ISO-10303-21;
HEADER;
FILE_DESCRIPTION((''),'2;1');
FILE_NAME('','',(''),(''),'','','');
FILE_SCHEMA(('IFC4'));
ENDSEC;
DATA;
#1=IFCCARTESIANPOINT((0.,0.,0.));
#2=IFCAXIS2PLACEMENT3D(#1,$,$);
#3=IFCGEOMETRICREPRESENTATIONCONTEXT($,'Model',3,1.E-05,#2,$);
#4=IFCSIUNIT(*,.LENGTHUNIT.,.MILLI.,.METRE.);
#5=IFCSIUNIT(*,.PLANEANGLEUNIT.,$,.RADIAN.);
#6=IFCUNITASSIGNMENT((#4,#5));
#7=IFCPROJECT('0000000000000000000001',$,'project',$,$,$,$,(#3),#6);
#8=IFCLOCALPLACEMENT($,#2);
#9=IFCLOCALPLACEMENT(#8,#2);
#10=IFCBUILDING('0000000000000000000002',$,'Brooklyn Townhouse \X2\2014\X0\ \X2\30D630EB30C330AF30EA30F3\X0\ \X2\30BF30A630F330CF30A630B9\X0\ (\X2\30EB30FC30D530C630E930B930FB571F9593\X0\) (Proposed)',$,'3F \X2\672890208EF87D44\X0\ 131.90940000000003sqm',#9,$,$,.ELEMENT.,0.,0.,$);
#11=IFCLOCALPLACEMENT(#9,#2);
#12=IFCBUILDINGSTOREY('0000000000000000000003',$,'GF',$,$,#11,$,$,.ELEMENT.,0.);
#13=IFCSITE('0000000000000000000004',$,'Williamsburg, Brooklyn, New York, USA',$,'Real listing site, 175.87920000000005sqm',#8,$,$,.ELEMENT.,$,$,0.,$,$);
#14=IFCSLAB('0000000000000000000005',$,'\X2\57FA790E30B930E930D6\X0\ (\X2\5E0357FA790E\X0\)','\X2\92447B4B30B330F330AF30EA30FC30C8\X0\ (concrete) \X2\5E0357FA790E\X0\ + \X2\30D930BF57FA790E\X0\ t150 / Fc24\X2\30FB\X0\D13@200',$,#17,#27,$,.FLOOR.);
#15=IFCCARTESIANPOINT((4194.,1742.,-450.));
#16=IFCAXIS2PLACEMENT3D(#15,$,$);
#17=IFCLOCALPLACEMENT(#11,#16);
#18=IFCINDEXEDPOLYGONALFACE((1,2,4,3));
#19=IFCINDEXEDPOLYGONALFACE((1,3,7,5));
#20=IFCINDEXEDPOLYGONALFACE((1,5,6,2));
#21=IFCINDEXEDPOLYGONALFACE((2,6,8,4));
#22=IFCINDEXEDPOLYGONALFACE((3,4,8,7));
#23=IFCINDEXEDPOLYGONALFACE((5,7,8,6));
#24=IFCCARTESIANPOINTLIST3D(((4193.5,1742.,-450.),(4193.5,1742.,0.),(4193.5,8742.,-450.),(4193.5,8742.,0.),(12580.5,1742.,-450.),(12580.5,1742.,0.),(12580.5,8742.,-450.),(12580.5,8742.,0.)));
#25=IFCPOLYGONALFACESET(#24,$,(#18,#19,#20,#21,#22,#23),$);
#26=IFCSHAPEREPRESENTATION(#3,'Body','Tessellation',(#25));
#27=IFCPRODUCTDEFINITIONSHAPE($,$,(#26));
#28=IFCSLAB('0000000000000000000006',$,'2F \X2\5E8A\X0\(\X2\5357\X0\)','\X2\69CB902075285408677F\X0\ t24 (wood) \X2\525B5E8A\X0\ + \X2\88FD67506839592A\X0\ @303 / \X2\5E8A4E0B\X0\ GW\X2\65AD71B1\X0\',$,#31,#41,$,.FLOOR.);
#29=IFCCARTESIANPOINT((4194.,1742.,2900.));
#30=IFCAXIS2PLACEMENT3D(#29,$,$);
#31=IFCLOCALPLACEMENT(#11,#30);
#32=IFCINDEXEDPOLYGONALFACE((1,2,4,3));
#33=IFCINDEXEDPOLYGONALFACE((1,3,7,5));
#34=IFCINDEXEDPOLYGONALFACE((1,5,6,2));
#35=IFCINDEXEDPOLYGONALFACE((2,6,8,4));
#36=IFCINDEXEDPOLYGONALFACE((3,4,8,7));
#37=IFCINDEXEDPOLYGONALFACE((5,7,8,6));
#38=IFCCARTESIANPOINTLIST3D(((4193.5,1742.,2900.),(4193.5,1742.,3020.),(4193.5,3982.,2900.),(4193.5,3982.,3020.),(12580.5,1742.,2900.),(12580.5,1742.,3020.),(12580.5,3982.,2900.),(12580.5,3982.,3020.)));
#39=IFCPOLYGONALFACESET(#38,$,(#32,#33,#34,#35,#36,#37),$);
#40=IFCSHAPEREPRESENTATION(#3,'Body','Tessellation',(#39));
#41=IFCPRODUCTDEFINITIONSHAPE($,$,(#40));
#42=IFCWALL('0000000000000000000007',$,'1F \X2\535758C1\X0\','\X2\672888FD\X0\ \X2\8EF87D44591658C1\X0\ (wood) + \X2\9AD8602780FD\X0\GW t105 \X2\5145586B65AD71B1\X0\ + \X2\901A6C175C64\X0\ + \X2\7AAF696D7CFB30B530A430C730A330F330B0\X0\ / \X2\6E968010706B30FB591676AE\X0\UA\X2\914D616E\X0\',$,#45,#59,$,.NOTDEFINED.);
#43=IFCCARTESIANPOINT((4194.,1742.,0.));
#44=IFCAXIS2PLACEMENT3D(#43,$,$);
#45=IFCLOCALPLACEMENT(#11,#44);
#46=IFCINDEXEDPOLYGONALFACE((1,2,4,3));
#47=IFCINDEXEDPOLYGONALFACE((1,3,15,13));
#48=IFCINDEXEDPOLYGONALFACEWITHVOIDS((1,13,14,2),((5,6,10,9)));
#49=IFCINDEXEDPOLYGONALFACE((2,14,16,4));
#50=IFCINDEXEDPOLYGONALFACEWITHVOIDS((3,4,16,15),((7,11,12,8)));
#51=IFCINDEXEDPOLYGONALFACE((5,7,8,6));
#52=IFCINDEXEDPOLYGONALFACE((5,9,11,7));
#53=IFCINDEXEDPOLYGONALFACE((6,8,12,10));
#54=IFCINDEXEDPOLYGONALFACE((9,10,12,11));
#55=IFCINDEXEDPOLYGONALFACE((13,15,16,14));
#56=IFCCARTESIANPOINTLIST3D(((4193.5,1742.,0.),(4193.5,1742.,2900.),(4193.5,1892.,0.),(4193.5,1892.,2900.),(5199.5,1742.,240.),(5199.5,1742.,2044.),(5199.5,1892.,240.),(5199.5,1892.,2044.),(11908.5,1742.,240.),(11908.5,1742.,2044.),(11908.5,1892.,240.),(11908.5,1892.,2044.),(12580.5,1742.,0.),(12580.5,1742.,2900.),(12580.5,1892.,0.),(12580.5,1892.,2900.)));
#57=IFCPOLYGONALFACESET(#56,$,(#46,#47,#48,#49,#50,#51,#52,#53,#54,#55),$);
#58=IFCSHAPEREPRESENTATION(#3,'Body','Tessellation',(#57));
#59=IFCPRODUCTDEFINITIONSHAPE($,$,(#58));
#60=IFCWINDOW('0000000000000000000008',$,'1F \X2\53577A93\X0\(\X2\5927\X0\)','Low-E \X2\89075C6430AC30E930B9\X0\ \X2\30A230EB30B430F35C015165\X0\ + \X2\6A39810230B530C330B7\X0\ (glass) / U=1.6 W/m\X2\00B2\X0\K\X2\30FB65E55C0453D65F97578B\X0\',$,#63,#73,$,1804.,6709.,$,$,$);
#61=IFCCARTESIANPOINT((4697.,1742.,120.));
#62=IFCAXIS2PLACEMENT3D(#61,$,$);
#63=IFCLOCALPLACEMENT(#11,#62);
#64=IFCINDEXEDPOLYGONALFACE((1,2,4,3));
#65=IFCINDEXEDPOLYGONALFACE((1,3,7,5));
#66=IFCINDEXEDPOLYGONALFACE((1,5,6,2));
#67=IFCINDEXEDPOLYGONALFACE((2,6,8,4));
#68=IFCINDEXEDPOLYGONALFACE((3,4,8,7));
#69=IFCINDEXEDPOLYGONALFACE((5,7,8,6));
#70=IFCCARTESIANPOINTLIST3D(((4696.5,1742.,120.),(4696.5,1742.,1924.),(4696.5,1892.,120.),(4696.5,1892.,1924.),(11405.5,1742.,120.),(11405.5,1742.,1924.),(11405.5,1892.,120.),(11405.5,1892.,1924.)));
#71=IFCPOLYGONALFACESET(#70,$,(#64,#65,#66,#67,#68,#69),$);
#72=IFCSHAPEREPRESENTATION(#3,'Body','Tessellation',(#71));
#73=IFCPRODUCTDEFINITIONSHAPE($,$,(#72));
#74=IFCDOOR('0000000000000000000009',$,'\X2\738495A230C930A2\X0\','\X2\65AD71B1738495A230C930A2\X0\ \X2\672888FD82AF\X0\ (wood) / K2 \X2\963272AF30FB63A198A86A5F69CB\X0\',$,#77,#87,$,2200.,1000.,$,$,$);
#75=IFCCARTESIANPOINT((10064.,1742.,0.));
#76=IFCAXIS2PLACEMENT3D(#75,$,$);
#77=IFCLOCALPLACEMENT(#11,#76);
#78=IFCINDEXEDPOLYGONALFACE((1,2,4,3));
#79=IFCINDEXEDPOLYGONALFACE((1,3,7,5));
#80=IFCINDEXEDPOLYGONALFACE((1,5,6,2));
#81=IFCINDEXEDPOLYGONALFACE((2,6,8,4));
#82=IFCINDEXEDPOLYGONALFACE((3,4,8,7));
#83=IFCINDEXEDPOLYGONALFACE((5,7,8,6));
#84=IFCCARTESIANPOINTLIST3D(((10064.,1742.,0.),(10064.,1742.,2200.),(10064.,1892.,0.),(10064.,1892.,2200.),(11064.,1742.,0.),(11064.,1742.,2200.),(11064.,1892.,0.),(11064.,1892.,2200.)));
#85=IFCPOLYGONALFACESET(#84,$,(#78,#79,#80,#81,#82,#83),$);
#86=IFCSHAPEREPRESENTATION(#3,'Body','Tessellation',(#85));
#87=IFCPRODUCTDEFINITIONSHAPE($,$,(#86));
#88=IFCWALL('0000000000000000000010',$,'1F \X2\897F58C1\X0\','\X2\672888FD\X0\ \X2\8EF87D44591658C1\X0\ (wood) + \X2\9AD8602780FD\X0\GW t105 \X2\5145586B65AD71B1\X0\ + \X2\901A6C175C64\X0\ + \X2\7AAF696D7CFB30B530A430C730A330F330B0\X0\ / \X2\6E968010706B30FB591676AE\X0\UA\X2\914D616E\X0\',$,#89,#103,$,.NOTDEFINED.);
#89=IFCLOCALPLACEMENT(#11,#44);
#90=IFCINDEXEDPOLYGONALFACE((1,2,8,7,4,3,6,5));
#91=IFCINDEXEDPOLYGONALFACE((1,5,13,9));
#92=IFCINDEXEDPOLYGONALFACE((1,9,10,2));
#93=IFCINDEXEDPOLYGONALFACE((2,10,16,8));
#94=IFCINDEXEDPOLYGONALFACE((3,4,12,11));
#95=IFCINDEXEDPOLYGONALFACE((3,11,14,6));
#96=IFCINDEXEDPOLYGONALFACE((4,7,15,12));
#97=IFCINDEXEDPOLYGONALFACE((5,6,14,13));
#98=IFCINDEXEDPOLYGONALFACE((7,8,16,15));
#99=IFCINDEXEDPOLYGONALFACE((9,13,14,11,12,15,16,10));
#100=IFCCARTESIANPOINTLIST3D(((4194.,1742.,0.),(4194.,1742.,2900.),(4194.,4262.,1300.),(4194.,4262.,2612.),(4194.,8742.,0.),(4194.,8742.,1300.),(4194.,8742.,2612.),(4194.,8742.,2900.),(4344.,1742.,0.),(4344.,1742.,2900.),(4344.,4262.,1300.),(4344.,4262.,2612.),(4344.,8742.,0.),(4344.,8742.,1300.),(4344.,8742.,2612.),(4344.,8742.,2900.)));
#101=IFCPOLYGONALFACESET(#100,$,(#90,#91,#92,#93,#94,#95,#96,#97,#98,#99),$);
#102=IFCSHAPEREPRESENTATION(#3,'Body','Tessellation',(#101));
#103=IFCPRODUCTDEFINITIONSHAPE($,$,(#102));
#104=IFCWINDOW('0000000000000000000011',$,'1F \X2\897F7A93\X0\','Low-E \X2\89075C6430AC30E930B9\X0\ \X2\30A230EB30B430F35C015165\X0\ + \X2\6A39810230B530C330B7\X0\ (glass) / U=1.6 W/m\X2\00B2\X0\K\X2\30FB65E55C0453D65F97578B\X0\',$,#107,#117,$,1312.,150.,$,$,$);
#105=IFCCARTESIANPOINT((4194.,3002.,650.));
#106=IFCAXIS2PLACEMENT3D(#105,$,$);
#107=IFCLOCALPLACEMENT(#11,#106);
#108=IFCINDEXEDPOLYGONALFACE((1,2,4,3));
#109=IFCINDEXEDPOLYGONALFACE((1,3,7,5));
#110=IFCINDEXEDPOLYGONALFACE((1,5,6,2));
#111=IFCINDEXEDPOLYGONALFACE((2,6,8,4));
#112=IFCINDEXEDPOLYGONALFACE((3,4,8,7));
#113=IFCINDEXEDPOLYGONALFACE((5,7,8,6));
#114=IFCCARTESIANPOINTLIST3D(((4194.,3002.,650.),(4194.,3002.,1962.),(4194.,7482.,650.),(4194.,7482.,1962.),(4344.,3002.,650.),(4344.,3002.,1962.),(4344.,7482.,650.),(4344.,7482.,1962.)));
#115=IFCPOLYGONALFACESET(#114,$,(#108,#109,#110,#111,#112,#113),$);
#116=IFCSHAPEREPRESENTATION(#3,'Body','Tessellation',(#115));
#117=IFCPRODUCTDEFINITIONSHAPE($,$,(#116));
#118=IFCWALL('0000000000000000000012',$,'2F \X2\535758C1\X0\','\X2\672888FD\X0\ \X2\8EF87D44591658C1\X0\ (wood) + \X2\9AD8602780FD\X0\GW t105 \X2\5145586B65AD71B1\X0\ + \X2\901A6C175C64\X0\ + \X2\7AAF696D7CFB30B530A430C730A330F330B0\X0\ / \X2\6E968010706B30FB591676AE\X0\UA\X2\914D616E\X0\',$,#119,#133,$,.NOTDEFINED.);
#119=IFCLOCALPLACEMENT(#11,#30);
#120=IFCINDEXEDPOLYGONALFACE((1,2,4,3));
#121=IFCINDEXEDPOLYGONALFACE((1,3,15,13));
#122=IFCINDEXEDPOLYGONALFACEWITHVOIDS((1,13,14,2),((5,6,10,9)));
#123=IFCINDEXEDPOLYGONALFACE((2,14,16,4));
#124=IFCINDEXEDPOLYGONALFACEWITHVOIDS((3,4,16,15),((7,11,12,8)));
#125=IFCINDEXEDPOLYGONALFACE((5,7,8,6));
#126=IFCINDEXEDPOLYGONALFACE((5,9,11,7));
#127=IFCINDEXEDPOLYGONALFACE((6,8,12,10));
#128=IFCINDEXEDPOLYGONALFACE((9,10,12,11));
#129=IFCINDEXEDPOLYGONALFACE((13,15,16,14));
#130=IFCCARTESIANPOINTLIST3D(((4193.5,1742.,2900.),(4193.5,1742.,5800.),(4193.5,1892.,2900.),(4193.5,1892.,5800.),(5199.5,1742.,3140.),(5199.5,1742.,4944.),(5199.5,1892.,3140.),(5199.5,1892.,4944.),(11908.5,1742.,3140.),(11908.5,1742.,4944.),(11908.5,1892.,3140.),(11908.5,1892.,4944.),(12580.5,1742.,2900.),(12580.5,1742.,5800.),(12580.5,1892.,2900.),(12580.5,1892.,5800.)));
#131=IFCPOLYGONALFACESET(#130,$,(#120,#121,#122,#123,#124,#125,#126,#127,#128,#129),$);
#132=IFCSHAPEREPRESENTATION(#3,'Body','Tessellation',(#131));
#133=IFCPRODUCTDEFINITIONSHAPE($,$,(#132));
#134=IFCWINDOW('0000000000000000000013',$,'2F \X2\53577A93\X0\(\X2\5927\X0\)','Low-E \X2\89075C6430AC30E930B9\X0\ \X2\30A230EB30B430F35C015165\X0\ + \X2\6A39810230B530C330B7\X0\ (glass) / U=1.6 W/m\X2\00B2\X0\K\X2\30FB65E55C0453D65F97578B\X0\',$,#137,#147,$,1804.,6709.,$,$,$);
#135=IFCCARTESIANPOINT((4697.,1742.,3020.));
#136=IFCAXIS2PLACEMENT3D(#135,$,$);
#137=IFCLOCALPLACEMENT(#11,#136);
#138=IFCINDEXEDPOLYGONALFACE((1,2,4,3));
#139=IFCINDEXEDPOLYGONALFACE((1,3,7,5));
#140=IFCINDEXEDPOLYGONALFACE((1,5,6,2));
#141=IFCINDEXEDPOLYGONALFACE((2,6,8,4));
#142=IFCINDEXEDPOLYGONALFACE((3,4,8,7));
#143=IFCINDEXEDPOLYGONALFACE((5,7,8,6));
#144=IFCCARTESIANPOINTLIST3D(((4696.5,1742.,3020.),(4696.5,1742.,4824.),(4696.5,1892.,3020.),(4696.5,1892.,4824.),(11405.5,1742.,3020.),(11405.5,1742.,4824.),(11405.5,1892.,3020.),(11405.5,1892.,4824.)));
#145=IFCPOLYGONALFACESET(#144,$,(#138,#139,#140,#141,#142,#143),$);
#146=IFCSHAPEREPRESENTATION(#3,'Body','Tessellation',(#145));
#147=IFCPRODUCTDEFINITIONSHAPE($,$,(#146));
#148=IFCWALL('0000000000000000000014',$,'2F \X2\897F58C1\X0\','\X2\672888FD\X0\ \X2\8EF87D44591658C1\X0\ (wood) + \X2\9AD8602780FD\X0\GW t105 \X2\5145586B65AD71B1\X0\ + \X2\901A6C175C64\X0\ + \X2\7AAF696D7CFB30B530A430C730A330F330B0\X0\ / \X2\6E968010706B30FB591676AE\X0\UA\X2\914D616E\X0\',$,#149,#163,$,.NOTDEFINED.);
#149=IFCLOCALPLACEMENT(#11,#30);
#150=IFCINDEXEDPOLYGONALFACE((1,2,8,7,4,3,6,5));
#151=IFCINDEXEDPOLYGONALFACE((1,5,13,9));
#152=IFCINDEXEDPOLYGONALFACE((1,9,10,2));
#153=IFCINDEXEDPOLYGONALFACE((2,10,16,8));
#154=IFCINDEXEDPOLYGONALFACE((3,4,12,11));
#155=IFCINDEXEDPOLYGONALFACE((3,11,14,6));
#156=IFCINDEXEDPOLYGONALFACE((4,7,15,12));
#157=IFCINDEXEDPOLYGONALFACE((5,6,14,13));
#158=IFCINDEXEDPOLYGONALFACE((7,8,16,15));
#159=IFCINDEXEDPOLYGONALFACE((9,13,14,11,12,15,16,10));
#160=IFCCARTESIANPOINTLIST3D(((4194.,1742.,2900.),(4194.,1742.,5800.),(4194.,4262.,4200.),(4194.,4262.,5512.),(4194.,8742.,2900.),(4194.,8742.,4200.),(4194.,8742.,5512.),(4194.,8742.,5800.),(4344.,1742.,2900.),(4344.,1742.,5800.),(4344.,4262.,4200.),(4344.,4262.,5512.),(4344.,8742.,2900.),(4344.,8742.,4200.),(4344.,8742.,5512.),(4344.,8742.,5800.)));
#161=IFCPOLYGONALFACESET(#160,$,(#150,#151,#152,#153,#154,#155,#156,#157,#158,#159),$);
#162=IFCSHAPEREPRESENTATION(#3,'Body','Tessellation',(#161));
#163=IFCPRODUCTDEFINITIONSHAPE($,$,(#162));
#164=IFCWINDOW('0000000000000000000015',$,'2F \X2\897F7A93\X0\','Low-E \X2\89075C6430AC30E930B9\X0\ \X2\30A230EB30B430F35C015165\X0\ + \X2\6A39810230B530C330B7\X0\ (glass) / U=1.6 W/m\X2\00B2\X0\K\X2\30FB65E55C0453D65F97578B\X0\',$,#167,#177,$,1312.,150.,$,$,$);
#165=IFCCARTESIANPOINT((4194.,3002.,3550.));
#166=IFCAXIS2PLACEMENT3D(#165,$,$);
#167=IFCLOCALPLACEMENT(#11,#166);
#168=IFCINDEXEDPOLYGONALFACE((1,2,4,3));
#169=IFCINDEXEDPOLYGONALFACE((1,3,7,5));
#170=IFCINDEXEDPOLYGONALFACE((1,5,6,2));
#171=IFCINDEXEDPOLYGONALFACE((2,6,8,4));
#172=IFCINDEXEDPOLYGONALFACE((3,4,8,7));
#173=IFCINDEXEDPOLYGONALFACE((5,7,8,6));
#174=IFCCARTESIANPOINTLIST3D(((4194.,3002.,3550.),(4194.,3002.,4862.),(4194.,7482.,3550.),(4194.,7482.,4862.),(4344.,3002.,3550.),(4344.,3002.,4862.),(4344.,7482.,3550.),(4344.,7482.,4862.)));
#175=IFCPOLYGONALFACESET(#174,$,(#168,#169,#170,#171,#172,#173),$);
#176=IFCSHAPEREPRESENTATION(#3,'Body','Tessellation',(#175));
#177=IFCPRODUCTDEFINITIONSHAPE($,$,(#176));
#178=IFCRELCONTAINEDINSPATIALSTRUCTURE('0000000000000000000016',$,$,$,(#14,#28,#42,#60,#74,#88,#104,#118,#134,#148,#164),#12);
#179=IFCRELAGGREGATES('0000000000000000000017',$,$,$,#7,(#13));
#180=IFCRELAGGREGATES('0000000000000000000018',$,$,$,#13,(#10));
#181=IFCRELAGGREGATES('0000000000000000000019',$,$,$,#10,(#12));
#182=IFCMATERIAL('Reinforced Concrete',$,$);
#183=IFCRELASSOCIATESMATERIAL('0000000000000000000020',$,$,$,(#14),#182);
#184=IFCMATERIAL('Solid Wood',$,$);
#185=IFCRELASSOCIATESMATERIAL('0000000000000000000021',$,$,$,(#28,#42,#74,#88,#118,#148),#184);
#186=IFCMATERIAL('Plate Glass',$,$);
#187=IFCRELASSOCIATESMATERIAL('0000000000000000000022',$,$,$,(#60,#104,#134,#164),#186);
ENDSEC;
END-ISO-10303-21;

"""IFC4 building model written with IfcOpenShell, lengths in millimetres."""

from ifc_helpers import new_model, si_unit, frame, frame_2d, origin, place, context, project, spatial, rectangle, extrude, material, element, fill, save


model = new_model("IFC4")

# Units and contexts
model_context = context("Model", 3, precision=1e-05, world=origin())
ifc_project = project(units=[si_unit("LENGTHUNIT", "METRE", prefix="MILLI"), si_unit("PLANEANGLEUNIT", "RADIAN")], contexts=[model_context])

# Site, building, storey
site_placement = place(None, origin())
site = spatial("IfcSite", under=ifc_project, at=site_placement, Name="Williamsburg, Brooklyn, New York, USA", ObjectType="Real listing site, 175.87920000000005sqm", CompositionType="ELEMENT", RefElevation=0.0)
building_placement = place(site_placement, origin())
building = spatial("IfcBuilding", under=site, at=building_placement, Name="Brooklyn Townhouse — ブルックリン タウンハウス (ルーフテラス・土間) (Proposed)", ObjectType="3F 木造軸組 131.90940000000003sqm", CompositionType="ELEMENT", ElevationOfRefHeight=0.0, ElevationOfTerrain=0.0)
storey_placement = place(building_placement, origin())
storey = spatial("IfcBuildingStorey", under=building, at=storey_placement, Name="GF", CompositionType="ELEMENT", Elevation=0.0)

# Slabs
ifc_material_1 = material(Name="Reinforced Concrete")
slab_1_placement = place(storey_placement, frame((4194.0, 1742.0, -450.0)))
element("IfcSlab", 1, at=slab_1_placement, inside=storey, material=ifc_material_1, Name="基礎スラブ (布基礎)", Description="鉄筋コンクリート (concrete) 布基礎 + ベタ基礎 t150 / Fc24・D13@200", PredefinedType="FLOOR", context=model_context, shape_type="SweptSolid", body=[
    extrude(rectangle(XDim=8387.0, YDim=7000.0, at=frame_2d((4193.0, 3500.0))), frame((4194.0, 1742.0, -450.0)), (0.0, 0.0, 1.0), 450.0),
])
ifc_material_2 = material(Name="Solid Wood")
slab_2_placement = place(storey_placement, frame((4194.0, 1742.0, 2900.0)))
element("IfcSlab", 2, at=slab_2_placement, inside=storey, material=ifc_material_2, Name="2F 床(南)", Description="構造用合板 t24 (wood) 剛床 + 製材根太 @303 / 床下 GW断熱", PredefinedType="FLOOR", context=model_context, shape_type="SweptSolid", body=[
    extrude(rectangle(XDim=8387.0, YDim=2240.0, at=frame_2d((4193.0, 1120.0))), frame((4194.0, 1742.0, 2900.0)), (0.0, 0.0, 1.0), 120.0),
])

# Wall, openings, window, door
wall_1_placement = place(storey_placement, frame((4194.0, 1742.0, 0.0)))
wall_1 = element("IfcWall", 3, at=wall_1_placement, inside=storey, material=ifc_material_2, Name="1F 南壁", Description="木製 軸組外壁 (wood) + 高性能GW t105 充填断熱 + 通気層 + 窯業系サイディング / 準耐火・外皮UA配慮", PredefinedType="NOTDEFINED", context=model_context, shape_type="SweptSolid", body=[
    extrude(rectangle(XDim=8387.0, YDim=150.0, at=frame_2d((4193.0, 75.0))), frame((4194.0, 1742.0, 0.0)), (0.0, 0.0, 1.0), 2900.0),
])
opening_1_placement = place(storey_placement, frame((4697.0, 1742.0, 120.0)))
opening_1 = element("IfcOpeningElement", 4, at=opening_1_placement, cuts=wall_1, PredefinedType="NOTDEFINED", context=model_context, shape_type="SweptSolid", body=[
    extrude(rectangle(XDim=6709.0, YDim=150.0, at=frame_2d((3354.0, 75.0))), frame((4697.0, 1742.0, 120.0)), (0.0, 0.0, 1.0), 1804.0),
])
opening_2_placement = place(storey_placement, frame((10064.0, 1742.0, 0.0)))
opening_2 = element("IfcOpeningElement", 5, at=opening_2_placement, cuts=wall_1, PredefinedType="NOTDEFINED", context=model_context, shape_type="SweptSolid", body=[
    extrude(rectangle(XDim=1000.0, YDim=150.0, at=frame_2d((500.0, 75.0))), frame((10064.0, 1742.0, 0.0)), (0.0, 0.0, 1.0), 2200.0),
])
ifc_material_3 = material(Name="Plate Glass")
window_1_placement = place(storey_placement, frame((4697.0, 1742.0, 120.0)))
window_1 = element("IfcWindow", 6, at=window_1_placement, inside=storey, material=ifc_material_3, Name="1F 南窓(大)", Description="Low-E 複層ガラス アルゴン封入 + 樹脂サッシ (glass) / U=1.6 W/m²K・日射取得型", OverallHeight=1804.0, OverallWidth=6709.0, context=model_context, shape_type="SweptSolid", body=[
    extrude(rectangle(XDim=6709.0, YDim=150.0, at=frame_2d((3354.0, 75.0))), frame((4697.0, 1742.0, 120.0)), (0.0, 0.0, 1.0), 1804.0),
])
fill(opening_1, window_1)
door_placement = place(storey_placement, frame((10064.0, 1742.0, 0.0)))
door = element("IfcDoor", 7, at=door_placement, inside=storey, material=ifc_material_2, Name="玄関ドア", Description="断熱玄関ドア 木製芯 (wood) / K2 防犯・採風機構", OverallHeight=2200.0, OverallWidth=1000.0, context=model_context, shape_type="SweptSolid", body=[
    extrude(rectangle(XDim=1000.0, YDim=150.0, at=frame_2d((500.0, 75.0))), frame((10064.0, 1742.0, 0.0)), (0.0, 0.0, 1.0), 2200.0),
])
fill(opening_2, door)

# Walls, openings, windows
wall_2_placement = place(storey_placement, frame((4194.0, 1742.0, 0.0)))
wall_2 = element("IfcWall", 8, at=wall_2_placement, inside=storey, material=ifc_material_2, Name="1F 西壁", Description="木製 軸組外壁 (wood) + 高性能GW t105 充填断熱 + 通気層 + 窯業系サイディング / 準耐火・外皮UA配慮", PredefinedType="NOTDEFINED", context=model_context, shape_type="SweptSolid", body=[
    extrude(rectangle(XDim=150.0, YDim=7000.0, at=frame_2d((75.0, 3500.0))), frame((4194.0, 1742.0, 0.0)), (0.0, 0.0, 1.0), 2900.0),
])
opening_3_placement = place(storey_placement, frame((4194.0, 3002.0, 650.0)))
opening_3 = element("IfcOpeningElement", 9, at=opening_3_placement, cuts=wall_2, PredefinedType="NOTDEFINED", context=model_context, shape_type="SweptSolid", body=[
    extrude(rectangle(XDim=150.0, YDim=4480.0, at=frame_2d((75.0, 2240.0))), frame((4194.0, 3002.0, 650.0)), (0.0, 0.0, 1.0), 1312.0),
])
window_2_placement = place(storey_placement, frame((4194.0, 3002.0, 650.0)))
window_2 = element("IfcWindow", 10, at=window_2_placement, inside=storey, material=ifc_material_3, Name="1F 西窓", Description="Low-E 複層ガラス アルゴン封入 + 樹脂サッシ (glass) / U=1.6 W/m²K・日射取得型", OverallHeight=1312.0, OverallWidth=150.0, context=model_context, shape_type="SweptSolid", body=[
    extrude(rectangle(XDim=150.0, YDim=4480.0, at=frame_2d((75.0, 2240.0))), frame((4194.0, 3002.0, 650.0)), (0.0, 0.0, 1.0), 1312.0),
])
fill(opening_3, window_2)
wall_3_placement = place(storey_placement, frame((4194.0, 1742.0, 2900.0)))
wall_3 = element("IfcWall", 11, at=wall_3_placement, inside=storey, material=ifc_material_2, Name="2F 南壁", Description="木製 軸組外壁 (wood) + 高性能GW t105 充填断熱 + 通気層 + 窯業系サイディング / 準耐火・外皮UA配慮", PredefinedType="NOTDEFINED", context=model_context, shape_type="SweptSolid", body=[
    extrude(rectangle(XDim=8387.0, YDim=150.0, at=frame_2d((4193.0, 75.0))), frame((4194.0, 1742.0, 2900.0)), (0.0, 0.0, 1.0), 2900.0),
])
opening_4_placement = place(storey_placement, frame((4697.0, 1742.0, 3020.0)))
opening_4 = element("IfcOpeningElement", 12, at=opening_4_placement, cuts=wall_3, PredefinedType="NOTDEFINED", context=model_context, shape_type="SweptSolid", body=[
    extrude(rectangle(XDim=6709.0, YDim=150.0, at=frame_2d((3354.0, 75.0))), frame((4697.0, 1742.0, 3020.0)), (0.0, 0.0, 1.0), 1804.0),
])
window_3_placement = place(storey_placement, frame((4697.0, 1742.0, 3020.0)))
window_3 = element("IfcWindow", 13, at=window_3_placement, inside=storey, material=ifc_material_3, Name="2F 南窓(大)", Description="Low-E 複層ガラス アルゴン封入 + 樹脂サッシ (glass) / U=1.6 W/m²K・日射取得型", OverallHeight=1804.0, OverallWidth=6709.0, context=model_context, shape_type="SweptSolid", body=[
    extrude(rectangle(XDim=6709.0, YDim=150.0, at=frame_2d((3354.0, 75.0))), frame((4697.0, 1742.0, 3020.0)), (0.0, 0.0, 1.0), 1804.0),
])
fill(opening_4, window_3)
wall_4_placement = place(storey_placement, frame((4194.0, 1742.0, 2900.0)))
wall_4 = element("IfcWall", 14, at=wall_4_placement, inside=storey, material=ifc_material_2, Name="2F 西壁", Description="木製 軸組外壁 (wood) + 高性能GW t105 充填断熱 + 通気層 + 窯業系サイディング / 準耐火・外皮UA配慮", PredefinedType="NOTDEFINED", context=model_context, shape_type="SweptSolid", body=[
    extrude(rectangle(XDim=150.0, YDim=7000.0, at=frame_2d((75.0, 3500.0))), frame((4194.0, 1742.0, 2900.0)), (0.0, 0.0, 1.0), 2900.0),
])
opening_5_placement = place(storey_placement, frame((4194.0, 3002.0, 3550.0)))
opening_5 = element("IfcOpeningElement", 15, at=opening_5_placement, cuts=wall_4, PredefinedType="NOTDEFINED", context=model_context, shape_type="SweptSolid", body=[
    extrude(rectangle(XDim=150.0, YDim=4480.0, at=frame_2d((75.0, 2240.0))), frame((4194.0, 3002.0, 3550.0)), (0.0, 0.0, 1.0), 1312.0),
])
window_4_placement = place(storey_placement, frame((4194.0, 3002.0, 3550.0)))
window_4 = element("IfcWindow", 16, at=window_4_placement, inside=storey, material=ifc_material_3, Name="2F 西窓", Description="Low-E 複層ガラス アルゴン封入 + 樹脂サッシ (glass) / U=1.6 W/m²K・日射取得型", OverallHeight=1312.0, OverallWidth=150.0, context=model_context, shape_type="SweptSolid", body=[
    extrude(rectangle(XDim=150.0, YDim=4480.0, at=frame_2d((75.0, 2240.0))), frame((4194.0, 3002.0, 3550.0)), (0.0, 0.0, 1.0), 1312.0),
])
fill(opening_5, window_4)

save(model, "model.ifc")
